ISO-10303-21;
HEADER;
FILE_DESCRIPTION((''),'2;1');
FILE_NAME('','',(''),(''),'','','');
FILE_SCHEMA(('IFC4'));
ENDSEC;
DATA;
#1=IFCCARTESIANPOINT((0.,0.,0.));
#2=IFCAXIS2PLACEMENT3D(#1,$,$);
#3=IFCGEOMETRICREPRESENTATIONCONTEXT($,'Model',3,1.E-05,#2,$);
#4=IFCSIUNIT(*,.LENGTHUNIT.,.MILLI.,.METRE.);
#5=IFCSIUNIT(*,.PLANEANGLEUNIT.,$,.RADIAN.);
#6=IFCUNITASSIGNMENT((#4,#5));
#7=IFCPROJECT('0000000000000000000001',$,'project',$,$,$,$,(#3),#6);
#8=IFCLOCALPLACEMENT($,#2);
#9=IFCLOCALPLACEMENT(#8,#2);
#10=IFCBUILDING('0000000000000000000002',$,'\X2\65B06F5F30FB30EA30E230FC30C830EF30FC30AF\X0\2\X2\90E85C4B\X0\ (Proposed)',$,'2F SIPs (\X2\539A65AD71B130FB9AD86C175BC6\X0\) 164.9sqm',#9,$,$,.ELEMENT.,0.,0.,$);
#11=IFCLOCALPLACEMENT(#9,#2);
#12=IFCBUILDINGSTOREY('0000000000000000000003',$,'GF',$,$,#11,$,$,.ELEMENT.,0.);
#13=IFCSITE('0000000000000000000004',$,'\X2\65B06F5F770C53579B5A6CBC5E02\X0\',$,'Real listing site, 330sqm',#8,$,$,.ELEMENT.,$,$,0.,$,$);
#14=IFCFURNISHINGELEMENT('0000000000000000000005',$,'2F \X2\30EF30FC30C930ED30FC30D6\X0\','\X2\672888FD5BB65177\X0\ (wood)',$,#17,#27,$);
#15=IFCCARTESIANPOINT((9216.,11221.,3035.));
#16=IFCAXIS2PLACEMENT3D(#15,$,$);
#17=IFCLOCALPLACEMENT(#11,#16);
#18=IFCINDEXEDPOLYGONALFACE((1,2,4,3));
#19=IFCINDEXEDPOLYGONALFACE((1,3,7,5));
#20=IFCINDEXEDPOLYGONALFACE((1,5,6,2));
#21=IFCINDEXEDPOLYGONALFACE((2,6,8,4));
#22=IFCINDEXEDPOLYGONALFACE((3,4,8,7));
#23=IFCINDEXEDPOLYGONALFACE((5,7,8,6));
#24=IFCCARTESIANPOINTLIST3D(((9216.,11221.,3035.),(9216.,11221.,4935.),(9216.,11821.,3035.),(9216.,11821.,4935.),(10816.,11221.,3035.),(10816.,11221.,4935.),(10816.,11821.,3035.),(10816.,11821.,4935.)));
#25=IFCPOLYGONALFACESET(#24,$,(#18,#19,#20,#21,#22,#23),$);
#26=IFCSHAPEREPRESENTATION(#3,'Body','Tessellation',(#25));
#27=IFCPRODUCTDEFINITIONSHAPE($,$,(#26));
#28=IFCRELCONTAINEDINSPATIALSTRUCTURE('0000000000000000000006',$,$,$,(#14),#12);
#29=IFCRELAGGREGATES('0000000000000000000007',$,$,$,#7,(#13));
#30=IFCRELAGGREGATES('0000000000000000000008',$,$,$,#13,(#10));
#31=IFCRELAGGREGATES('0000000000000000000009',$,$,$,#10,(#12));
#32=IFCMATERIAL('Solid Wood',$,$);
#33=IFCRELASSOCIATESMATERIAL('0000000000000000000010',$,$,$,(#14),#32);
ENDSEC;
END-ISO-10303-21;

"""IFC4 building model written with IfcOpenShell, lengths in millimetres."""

from ifc_helpers import new_model, si_unit, frame, frame_2d, origin, place, context, project, spatial, rectangle, extrude, material, element, save


model = new_model("IFC4")

# Units and contexts
model_context = context("Model", 3, precision=1e-05, world=origin())
ifc_project = project(units=[si_unit("LENGTHUNIT", "METRE", prefix="MILLI"), si_unit("PLANEANGLEUNIT", "RADIAN")], contexts=[model_context])

# Site, building, storey
site_placement = place(None, origin())
site = spatial("IfcSite", under=ifc_project, at=site_placement, Name="新潟県南魚沼市", ObjectType="Real listing site, 330sqm", CompositionType="ELEMENT", RefElevation=0.0)
building_placement = place(site_placement, origin())
building = spatial("IfcBuilding", under=site, at=building_placement, Name="新潟・リモートワーク2部屋 (Proposed)", ObjectType="2F SIPs (厚断熱・高気密) 164.9sqm", CompositionType="ELEMENT", ElevationOfRefHeight=0.0, ElevationOfTerrain=0.0)
storey_placement = place(building_placement, origin())
storey = spatial("IfcBuildingStorey", under=building, at=storey_placement, Name="GF", CompositionType="ELEMENT", Elevation=0.0)

# Shared definitions
ifc_material_1 = material(Name="Solid Wood")

# Furnishing element
furnishing_1_placement = place(storey_placement, frame((9216.0, 11221.0, 3035.0)))
element("IfcFurnishingElement", 1, at=furnishing_1_placement, inside=storey, material=ifc_material_1, Name="2F ワードローブ", Description="木製家具 (wood)", context=model_context, shape_type="SweptSolid", body=[
    extrude(rectangle(XDim=1600.0, YDim=600.0, at=frame_2d((800.0, 300.0))), frame((9216.0, 11221.0, 3035.0)), (0.0, 0.0, 1.0), 1900.0),
])

save(model, "model.ifc")
